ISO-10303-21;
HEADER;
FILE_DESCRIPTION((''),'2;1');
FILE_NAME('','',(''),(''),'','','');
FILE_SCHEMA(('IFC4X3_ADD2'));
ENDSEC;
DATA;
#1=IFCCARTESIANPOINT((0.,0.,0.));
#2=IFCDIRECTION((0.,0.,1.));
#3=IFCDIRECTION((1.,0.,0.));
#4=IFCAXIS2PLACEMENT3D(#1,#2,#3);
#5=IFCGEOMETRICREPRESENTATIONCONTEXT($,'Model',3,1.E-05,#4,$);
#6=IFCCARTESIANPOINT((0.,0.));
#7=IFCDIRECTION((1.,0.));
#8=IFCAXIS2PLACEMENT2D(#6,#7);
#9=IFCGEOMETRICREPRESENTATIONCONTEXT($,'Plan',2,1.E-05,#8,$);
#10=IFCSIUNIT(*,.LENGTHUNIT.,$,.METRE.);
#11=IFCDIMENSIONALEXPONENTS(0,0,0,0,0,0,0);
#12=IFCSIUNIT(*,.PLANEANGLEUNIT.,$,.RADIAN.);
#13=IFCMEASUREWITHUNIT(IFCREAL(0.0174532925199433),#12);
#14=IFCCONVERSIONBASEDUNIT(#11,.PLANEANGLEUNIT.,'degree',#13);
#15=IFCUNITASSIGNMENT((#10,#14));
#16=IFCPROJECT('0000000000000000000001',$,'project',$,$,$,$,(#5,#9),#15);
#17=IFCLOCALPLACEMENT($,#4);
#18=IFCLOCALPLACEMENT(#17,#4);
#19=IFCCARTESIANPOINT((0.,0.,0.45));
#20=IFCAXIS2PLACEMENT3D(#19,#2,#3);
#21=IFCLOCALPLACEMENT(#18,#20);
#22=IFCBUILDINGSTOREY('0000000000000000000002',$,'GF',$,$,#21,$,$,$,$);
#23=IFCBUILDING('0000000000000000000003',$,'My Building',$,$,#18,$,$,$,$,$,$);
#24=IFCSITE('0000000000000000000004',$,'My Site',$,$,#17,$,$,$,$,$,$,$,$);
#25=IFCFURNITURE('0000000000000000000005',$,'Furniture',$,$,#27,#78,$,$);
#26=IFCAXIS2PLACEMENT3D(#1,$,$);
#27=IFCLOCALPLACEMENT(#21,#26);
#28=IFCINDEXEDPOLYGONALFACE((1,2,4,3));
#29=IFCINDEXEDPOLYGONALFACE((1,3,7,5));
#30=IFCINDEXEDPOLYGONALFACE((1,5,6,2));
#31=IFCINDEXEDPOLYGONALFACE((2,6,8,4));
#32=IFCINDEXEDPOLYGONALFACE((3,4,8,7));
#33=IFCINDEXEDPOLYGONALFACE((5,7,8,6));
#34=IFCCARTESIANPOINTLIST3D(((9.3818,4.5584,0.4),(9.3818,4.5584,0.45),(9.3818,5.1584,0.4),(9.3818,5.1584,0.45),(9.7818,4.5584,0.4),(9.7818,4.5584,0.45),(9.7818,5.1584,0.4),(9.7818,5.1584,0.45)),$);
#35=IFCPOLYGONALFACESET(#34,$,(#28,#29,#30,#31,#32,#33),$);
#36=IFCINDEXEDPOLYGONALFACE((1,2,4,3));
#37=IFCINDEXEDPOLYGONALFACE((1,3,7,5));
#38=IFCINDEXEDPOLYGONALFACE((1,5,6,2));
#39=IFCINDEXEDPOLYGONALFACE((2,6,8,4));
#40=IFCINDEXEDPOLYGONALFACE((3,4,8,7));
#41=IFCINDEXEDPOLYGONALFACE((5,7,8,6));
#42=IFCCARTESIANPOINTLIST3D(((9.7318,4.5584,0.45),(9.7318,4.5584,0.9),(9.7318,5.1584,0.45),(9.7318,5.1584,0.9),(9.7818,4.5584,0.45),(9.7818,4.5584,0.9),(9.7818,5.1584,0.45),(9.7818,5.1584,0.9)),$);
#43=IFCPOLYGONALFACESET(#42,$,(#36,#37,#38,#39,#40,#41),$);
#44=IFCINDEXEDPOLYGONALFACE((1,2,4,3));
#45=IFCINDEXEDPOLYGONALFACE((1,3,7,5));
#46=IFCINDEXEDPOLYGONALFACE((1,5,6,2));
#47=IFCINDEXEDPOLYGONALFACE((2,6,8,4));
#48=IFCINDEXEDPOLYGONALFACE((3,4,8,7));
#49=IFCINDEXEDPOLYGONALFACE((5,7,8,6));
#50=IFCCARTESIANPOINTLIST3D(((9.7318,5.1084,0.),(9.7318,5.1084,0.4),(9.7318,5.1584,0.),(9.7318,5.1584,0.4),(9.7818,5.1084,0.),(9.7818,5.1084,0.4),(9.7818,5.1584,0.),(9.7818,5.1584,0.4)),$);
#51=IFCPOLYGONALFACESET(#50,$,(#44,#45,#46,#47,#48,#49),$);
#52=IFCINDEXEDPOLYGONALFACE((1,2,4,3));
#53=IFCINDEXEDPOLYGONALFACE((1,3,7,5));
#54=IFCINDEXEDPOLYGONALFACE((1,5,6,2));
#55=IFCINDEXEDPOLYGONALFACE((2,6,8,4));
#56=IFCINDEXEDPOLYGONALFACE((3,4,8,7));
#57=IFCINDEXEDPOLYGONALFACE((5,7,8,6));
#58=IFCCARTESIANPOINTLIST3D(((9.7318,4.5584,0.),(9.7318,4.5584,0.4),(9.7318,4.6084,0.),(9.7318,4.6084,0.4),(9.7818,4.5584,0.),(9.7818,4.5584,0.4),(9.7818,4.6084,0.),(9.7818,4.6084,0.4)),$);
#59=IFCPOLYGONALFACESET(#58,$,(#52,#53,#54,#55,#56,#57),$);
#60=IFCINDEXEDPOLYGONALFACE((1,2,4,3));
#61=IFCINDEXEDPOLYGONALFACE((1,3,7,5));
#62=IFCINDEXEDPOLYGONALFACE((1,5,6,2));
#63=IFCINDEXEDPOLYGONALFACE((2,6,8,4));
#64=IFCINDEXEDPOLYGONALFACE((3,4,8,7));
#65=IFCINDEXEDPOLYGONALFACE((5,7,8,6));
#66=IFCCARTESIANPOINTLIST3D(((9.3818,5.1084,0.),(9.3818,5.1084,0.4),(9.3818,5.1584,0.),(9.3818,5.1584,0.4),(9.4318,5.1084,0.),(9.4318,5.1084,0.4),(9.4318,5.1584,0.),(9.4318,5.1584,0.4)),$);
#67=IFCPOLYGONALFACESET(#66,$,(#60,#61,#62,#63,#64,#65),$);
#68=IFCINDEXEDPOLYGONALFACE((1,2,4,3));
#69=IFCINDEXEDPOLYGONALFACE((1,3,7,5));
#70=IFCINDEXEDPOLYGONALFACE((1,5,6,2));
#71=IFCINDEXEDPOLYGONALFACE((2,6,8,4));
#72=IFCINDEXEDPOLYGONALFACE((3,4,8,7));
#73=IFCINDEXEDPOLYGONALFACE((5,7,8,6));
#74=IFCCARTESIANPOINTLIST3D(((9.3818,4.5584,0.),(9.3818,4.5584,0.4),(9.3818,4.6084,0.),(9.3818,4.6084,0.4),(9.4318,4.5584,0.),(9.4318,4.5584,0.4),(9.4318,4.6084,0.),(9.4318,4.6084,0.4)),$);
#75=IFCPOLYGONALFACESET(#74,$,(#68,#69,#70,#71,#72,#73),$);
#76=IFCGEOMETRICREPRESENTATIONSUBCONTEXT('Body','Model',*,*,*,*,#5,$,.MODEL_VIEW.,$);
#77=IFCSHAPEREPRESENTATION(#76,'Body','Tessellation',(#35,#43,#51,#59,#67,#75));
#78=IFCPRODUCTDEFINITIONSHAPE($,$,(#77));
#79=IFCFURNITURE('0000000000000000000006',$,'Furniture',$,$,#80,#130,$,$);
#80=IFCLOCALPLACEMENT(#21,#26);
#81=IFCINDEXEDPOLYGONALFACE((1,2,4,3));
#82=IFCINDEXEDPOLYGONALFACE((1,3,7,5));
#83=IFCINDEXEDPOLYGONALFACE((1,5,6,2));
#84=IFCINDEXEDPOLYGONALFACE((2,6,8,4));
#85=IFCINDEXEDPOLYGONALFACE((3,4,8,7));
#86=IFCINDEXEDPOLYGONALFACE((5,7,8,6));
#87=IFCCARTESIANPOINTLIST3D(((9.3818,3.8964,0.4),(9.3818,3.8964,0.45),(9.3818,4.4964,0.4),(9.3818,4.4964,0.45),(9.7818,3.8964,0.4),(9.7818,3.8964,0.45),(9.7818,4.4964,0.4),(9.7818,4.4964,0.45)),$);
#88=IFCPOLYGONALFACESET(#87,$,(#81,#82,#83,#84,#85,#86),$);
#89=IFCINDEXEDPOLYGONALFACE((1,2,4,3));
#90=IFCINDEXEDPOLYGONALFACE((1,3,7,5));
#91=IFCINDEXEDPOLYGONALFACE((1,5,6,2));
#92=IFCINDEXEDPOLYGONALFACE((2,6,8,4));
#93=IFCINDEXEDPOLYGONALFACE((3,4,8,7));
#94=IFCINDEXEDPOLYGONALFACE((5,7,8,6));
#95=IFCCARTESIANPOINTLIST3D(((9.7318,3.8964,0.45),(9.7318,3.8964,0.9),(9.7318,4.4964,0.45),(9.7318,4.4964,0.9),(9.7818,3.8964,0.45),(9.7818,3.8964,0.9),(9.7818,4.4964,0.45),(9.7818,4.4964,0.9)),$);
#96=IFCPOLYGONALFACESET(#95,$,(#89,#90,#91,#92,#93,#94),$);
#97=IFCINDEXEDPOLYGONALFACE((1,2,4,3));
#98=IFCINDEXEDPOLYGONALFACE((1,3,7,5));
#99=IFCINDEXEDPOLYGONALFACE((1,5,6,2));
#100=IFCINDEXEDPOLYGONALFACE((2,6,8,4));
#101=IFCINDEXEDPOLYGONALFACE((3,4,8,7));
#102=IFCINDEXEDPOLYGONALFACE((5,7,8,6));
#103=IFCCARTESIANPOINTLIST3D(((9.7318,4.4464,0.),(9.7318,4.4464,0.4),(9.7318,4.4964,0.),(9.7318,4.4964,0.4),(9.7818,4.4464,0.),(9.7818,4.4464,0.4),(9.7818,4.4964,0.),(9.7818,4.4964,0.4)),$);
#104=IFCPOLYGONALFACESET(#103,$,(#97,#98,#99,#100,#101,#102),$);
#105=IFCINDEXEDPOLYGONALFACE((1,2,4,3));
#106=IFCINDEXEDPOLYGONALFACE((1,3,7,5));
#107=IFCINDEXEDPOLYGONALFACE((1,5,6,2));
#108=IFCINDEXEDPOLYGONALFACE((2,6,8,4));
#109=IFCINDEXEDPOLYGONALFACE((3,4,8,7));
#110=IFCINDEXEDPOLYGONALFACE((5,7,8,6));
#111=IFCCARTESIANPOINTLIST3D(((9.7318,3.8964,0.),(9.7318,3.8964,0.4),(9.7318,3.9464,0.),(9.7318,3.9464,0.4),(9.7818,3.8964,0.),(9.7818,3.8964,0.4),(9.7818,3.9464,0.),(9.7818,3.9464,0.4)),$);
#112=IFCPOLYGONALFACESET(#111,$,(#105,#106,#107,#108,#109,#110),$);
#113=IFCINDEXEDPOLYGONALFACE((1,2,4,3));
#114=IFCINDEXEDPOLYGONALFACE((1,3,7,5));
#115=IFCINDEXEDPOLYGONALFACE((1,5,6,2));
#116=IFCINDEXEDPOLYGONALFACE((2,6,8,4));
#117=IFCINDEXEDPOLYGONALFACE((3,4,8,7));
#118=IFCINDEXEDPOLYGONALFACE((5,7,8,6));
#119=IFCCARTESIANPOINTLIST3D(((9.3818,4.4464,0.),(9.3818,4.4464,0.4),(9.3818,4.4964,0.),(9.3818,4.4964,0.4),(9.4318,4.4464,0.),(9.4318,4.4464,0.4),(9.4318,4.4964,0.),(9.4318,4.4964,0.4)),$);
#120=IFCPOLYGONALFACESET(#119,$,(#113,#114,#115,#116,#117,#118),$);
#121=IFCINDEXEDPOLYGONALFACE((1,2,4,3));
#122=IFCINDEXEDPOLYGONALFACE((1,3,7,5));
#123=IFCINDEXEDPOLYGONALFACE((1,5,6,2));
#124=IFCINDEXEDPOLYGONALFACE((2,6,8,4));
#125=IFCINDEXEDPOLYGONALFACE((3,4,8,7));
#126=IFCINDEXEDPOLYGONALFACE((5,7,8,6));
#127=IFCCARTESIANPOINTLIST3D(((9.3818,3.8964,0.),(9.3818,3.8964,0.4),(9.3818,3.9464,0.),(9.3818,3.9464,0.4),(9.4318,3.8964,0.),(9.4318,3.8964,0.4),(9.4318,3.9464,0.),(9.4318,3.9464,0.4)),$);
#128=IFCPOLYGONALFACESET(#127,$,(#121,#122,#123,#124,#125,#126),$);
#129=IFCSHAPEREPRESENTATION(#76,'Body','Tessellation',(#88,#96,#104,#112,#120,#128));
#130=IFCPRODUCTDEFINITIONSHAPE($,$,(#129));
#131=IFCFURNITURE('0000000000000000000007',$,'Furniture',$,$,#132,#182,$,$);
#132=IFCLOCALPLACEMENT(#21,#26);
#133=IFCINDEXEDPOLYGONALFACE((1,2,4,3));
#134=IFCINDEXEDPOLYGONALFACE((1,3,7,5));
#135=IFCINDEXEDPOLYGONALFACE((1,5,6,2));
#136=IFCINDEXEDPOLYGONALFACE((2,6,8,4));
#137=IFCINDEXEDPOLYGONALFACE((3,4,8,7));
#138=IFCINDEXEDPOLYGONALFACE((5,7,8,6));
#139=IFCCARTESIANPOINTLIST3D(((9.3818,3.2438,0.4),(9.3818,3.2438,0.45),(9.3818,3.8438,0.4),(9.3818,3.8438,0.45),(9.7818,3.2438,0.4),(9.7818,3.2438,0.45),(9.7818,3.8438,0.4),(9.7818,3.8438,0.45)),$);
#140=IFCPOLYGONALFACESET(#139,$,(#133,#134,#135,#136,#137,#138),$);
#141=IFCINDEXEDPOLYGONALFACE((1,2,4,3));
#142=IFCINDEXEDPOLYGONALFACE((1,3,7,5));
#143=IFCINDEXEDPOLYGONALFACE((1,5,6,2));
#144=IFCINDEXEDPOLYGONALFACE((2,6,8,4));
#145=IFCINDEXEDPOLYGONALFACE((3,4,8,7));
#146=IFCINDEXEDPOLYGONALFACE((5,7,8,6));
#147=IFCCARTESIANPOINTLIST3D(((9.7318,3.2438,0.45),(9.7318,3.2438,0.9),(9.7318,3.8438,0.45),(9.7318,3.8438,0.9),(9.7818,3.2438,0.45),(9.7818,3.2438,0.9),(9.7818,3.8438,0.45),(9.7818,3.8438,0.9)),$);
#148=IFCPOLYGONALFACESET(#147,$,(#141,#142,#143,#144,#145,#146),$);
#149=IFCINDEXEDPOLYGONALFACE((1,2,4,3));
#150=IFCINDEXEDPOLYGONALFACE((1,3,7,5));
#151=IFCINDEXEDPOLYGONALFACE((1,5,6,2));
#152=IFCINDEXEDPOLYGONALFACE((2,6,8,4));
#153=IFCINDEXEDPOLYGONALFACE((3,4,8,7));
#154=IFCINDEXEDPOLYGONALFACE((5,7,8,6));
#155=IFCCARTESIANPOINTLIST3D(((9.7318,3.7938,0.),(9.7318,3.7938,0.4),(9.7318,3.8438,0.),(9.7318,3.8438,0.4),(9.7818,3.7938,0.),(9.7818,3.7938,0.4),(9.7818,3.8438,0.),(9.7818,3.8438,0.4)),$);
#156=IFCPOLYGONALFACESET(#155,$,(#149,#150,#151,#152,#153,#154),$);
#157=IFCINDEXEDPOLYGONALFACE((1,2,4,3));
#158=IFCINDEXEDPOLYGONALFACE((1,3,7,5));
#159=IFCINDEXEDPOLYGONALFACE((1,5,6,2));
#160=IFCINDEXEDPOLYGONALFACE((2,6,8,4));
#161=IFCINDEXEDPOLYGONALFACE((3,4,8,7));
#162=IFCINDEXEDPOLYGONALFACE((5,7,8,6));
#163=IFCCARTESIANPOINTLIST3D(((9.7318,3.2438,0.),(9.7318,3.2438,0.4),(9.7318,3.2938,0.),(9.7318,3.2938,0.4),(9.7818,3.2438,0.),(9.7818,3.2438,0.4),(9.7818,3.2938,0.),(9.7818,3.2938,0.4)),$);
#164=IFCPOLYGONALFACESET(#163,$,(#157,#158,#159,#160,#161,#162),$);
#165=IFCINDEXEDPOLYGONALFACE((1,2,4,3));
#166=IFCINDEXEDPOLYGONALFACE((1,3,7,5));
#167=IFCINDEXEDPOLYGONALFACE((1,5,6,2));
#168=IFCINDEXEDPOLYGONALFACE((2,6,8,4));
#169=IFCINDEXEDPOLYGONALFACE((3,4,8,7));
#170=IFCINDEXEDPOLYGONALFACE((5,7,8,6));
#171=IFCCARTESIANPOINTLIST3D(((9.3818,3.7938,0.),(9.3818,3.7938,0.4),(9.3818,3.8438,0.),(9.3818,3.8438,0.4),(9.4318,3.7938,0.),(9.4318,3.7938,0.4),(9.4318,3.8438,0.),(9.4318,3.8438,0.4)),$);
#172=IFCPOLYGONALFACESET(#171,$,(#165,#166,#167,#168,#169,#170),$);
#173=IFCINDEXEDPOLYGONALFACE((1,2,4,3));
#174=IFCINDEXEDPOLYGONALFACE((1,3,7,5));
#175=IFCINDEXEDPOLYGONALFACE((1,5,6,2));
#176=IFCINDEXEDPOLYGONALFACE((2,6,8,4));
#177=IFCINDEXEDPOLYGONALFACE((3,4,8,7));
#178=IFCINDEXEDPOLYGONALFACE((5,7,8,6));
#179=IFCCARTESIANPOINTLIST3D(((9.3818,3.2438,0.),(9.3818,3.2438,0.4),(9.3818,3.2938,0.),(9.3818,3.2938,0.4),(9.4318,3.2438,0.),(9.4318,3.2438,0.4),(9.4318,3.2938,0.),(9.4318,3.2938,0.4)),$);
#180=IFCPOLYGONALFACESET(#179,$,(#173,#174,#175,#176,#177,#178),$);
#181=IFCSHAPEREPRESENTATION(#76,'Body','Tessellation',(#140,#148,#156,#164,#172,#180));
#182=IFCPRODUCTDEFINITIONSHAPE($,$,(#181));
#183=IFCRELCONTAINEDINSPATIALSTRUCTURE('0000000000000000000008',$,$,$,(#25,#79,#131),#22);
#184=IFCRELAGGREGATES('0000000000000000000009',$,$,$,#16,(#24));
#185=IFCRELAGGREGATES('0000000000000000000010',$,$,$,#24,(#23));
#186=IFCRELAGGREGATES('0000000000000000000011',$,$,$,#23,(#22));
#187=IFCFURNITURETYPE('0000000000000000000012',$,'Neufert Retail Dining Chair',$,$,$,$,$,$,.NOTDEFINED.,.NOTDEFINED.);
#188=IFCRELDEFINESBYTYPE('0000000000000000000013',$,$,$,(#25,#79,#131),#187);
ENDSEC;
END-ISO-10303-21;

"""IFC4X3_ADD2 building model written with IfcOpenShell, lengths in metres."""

from ifc_helpers import new_model, entity, si_unit, converted_unit, frame, origin_with_axes, origin_2d_with_axis, place, context, subcontext, project, spatial, line, indexed_curve, outline, extrude, shape, source, transform, mapped, type_object, type_shapes, element, save


model = new_model("IFC4X3_ADD2")

# Units and contexts
model_context = context("Model", 3, precision=1e-05, world=origin_with_axes())
plan_context = context("Plan", 2, precision=1e-05, world=origin_2d_with_axis())
body_context_1 = subcontext(model_context, "Body", "Model", "MODEL_VIEW")
body_context_2 = subcontext(plan_context, "Body", "Plan", "PLAN_VIEW")
ifc_project = project(units=[si_unit("LENGTHUNIT", "METRE"), converted_unit("PLANEANGLEUNIT", "degree", entity("IfcReal", 0.0174532925199433), si_unit("PLANEANGLEUNIT", "RADIAN"), dimensions=[0, 0, 0, 0, 0, 0, 0])], contexts=[model_context, plan_context])

# Site, building, storey
site_placement = place(None, origin_with_axes())
site = spatial("IfcSite", under=ifc_project, at=site_placement, Name="My Site")
building_placement = place(site_placement, origin_with_axes())
building = spatial("IfcBuilding", under=site, at=building_placement, Name="My Building")
storey_placement = place(building_placement, frame((0.0, 0.0, 0.45), z_axis=(0.0, 0.0, 1.0), x_axis=(1.0, 0.0, 0.0)))
storey = spatial("IfcBuildingStorey", under=building, at=storey_placement, Name="GF")

# Furniture
furniture_type = type_object("IfcFurnitureType", Name="Neufert Retail Dining Chair", AssemblyPlace="NOTDEFINED", PredefinedType="NOTDEFINED")
shared_shape_1 = source(origin_with_axes(), body_context_1, "Body", "SweptSolid", [
    extrude(outline(indexed_curve([(-0.3, 0.0), (0.3, 0.0), (0.3, -0.4), (-0.3, -0.4)], segments=[line(1, 2, 3, 4, 1)])), frame((0.0, 0.0, 0.45), z_axis=(0.0, 0.0, 1.0), x_axis=(1.0, 0.0, 0.0)), (0.0, 0.0, -1.0), 0.05),
    extrude(outline(indexed_curve([(-0.3, 0.0), (0.3, 0.0), (0.3, -0.05), (-0.3, -0.05)], segments=[line(1, 2, 3, 4, 1)])), frame((0.0, 0.0, 0.9), z_axis=(0.0, 0.0, 1.0), x_axis=(1.0, 0.0, 0.0)), (0.0, 0.0, -1.0), 0.45),
    extrude(outline(indexed_curve([(-0.3, 0.0), (-0.25, 0.0), (-0.25, -0.05), (-0.3, -0.05)], segments=[line(1, 2, 3, 4, 1)])), origin_with_axes(), (0.0, 0.0, 1.0), 0.4),
    extrude(outline(indexed_curve([(0.3, 0.0), (0.25, 0.0), (0.25, -0.05), (0.3, -0.05)], segments=[line(1, 2, 3, 4, 1)])), origin_with_axes(), (0.0, 0.0, 1.0), 0.4),
    extrude(outline(indexed_curve([(-0.3, -0.4), (-0.25, -0.4), (-0.25, -0.35), (-0.3, -0.35)], segments=[line(1, 2, 3, 4, 1)])), origin_with_axes(), (0.0, 0.0, 1.0), 0.4),
    extrude(outline(indexed_curve([(0.3, -0.4), (0.25, -0.4), (0.25, -0.35), (0.3, -0.35)], segments=[line(1, 2, 3, 4, 1)])), origin_with_axes(), (0.0, 0.0, 1.0), 0.4),
])
shared_shape_2 = source(origin_with_axes(), body_context_2, "Body", "Curve2D", [
    entity("IfcIndexedPolyCurve", entity("IfcCartesianPointList2D", [[-0.3, -0.4], [0.3, -0.4]])),
    entity("IfcIndexedPolyCurve", entity("IfcCartesianPointList2D", [[-0.3, -0.4], [-0.3, -0.3], [-0.2121, -0.0879], [0.0, 0.0], [0.2121, -0.0879], [0.3, -0.3], [0.3, -0.4]]), [entity("IfcLineIndex", [1, 2]), entity("IfcArcIndex", [2, 3, 4]), entity("IfcArcIndex", [4, 5, 6]), entity("IfcLineIndex", [6, 7])]),
    entity("IfcIndexedPolyCurve", entity("IfcCartesianPointList2D", [[-0.26, -0.4], [-0.26, -0.3], [-0.1838, -0.1162], [0.0, -0.04], [0.1838, -0.1162], [0.26, -0.3], [0.26, -0.4]]), [entity("IfcLineIndex", [1, 2]), entity("IfcArcIndex", [2, 3, 4]), entity("IfcArcIndex", [4, 5, 6]), entity("IfcLineIndex", [6, 7])]),
])
type_shapes(furniture_type, [shared_shape_1, shared_shape_2])
for number, where, z_axis, x_axis, name in (
    (1, (9.7818, 4.8584, 0.0), (0.0, 0.0, 1.0), (-0.000001, -1.0, 0.0), "Furniture"),
    (2, (9.7818, 4.1964, 0.0), (0.0, 0.0, 1.0), (-0.000001, -1.0, 0.0), "Furniture"),
    (3, (9.7818, 3.5438, 0.0), (0.0, 0.0, 1.0), (-0.000001, -1.0, 0.0), "Furniture"),
):
    element("IfcFurniture", number, at=place(storey_placement, frame(where, z_axis=z_axis, x_axis=x_axis)), inside=storey, type_object=furniture_type, Name=name, shapes=[
        shape(body_context_1, "Body", "MappedRepresentation", [mapped(shared_shape_1, transform((0.0, 0.0, 0.0), x_axis=(1.0, 0.0, 0.0), y_axis=(0.0, 1.0, 0.0), z_axis=(0.0, 0.0, 1.0), scale=1.0))]),
        shape(body_context_2, "Body", "MappedRepresentation", [mapped(shared_shape_2, transform((0.0, 0.0, 0.0), x_axis=(1.0, 0.0, 0.0), y_axis=(0.0, 1.0, 0.0), z_axis=(0.0, 0.0, 1.0), scale=1.0))]),
    ])

save(model, "model.ifc")
